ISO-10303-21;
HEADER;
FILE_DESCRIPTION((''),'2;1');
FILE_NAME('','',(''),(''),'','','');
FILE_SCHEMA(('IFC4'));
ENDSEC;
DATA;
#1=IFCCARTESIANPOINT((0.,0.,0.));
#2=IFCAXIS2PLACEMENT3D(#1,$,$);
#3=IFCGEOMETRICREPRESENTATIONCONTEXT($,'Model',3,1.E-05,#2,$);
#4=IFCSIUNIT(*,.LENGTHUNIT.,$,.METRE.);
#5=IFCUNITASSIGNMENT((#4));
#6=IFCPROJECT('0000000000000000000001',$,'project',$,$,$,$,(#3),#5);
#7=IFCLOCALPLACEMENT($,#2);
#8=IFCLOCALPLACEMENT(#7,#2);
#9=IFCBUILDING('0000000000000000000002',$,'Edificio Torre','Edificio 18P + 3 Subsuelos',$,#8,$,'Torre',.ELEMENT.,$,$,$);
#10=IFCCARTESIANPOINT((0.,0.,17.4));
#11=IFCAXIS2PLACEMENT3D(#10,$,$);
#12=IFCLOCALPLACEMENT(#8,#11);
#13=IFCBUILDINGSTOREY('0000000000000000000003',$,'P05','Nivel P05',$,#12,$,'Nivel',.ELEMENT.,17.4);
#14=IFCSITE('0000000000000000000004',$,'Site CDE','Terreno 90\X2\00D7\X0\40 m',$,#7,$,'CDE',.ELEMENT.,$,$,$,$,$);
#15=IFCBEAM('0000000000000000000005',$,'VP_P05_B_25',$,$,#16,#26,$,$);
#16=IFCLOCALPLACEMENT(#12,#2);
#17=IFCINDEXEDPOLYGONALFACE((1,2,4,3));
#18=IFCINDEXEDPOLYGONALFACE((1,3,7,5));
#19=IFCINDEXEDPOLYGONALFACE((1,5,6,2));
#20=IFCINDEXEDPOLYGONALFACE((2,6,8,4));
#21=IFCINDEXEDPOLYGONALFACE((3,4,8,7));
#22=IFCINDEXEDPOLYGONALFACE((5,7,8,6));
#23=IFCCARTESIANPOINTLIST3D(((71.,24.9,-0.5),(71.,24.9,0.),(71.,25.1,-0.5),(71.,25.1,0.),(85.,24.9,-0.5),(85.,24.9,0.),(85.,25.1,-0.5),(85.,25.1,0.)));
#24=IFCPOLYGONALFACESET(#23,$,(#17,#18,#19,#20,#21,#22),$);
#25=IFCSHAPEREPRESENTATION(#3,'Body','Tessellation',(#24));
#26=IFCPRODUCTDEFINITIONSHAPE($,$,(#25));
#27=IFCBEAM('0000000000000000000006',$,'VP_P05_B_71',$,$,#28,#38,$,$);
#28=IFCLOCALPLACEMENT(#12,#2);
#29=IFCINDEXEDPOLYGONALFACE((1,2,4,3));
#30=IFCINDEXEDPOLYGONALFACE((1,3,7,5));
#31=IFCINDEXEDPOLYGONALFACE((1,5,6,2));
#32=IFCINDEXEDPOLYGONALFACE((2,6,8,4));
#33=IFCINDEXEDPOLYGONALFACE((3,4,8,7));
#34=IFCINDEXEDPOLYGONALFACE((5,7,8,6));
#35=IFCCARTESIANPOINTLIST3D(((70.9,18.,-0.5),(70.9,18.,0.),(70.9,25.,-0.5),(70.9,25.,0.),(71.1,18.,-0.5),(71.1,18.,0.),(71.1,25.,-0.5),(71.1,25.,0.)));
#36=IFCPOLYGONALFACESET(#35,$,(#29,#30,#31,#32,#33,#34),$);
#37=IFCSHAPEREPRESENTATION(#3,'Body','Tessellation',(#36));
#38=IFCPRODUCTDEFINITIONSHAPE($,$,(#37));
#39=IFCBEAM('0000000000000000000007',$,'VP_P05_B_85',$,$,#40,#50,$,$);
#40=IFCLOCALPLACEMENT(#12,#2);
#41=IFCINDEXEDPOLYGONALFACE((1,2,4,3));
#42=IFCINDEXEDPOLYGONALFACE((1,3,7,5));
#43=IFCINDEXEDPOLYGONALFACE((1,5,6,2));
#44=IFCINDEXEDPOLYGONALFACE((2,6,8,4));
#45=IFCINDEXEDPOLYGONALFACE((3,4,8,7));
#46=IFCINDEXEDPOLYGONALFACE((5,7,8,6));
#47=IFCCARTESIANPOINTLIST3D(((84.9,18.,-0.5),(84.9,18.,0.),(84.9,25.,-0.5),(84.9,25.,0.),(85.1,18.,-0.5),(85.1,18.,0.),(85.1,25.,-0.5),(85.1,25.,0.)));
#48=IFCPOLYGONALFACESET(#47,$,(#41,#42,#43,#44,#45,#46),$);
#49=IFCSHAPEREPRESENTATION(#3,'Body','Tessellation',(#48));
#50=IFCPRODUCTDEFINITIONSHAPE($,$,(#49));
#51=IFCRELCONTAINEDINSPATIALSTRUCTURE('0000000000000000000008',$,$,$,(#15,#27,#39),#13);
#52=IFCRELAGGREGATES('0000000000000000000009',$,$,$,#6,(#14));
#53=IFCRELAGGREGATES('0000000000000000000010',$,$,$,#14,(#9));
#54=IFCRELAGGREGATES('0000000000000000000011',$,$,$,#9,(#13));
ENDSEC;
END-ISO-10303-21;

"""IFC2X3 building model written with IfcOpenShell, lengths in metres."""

from ifc_helpers import new_model, si_unit, frame, origin, origin_2d, place, context, project, spatial, rectangle, extrude, element, save


model = new_model("IFC2X3")

# Units and contexts
model_context = context("Model", 3, precision=1e-05, world=origin())
ifc_project = project(units=[si_unit("LENGTHUNIT", "METRE")], contexts=[model_context])

# Site, building, storey
site_placement = place(None, origin())
site = spatial("IfcSite", under=ifc_project, at=site_placement, Name="Site CDE", Description="Terreno 90×40 m", LongName="CDE", CompositionType="ELEMENT")
building_placement = place(site_placement, origin())
building = spatial("IfcBuilding", under=site, at=building_placement, Name="Edificio Torre", Description="Edificio 18P + 3 Subsuelos", LongName="Torre", CompositionType="ELEMENT")
storey_placement = place(building_placement, frame((0.0, 0.0, 17.4)))
storey = spatial("IfcBuildingStorey", under=building, at=storey_placement, Name="P05", Description="Nivel P05", LongName="Nivel", CompositionType="ELEMENT", Elevation=17.4)

# Beams
for number, where, name in (
    (1, (78.0, 25.0, -0.5), "VP_P05_B_25"),
):
    element("IfcBeam", number, at=place(storey_placement, frame(where)), inside=storey, Name=name, context=model_context, shape_type="SweptSolid", body=[
        extrude(rectangle(XDim=14.0, YDim=0.2, at=origin_2d()), origin(), (0.0, 0.0, 1.0), 0.5),
    ])
for number, where, name in (
    (2, (71.0, 21.5, -0.5), "VP_P05_B_71"),
    (3, (85.0, 21.5, -0.5), "VP_P05_B_85"),
):
    element("IfcBeam", number, at=place(storey_placement, frame(where)), inside=storey, Name=name, context=model_context, shape_type="SweptSolid", body=[
        extrude(rectangle(XDim=0.2, YDim=7.0, at=origin_2d()), origin(), (0.0, 0.0, 1.0), 0.5),
    ])

save(model, "model.ifc")
